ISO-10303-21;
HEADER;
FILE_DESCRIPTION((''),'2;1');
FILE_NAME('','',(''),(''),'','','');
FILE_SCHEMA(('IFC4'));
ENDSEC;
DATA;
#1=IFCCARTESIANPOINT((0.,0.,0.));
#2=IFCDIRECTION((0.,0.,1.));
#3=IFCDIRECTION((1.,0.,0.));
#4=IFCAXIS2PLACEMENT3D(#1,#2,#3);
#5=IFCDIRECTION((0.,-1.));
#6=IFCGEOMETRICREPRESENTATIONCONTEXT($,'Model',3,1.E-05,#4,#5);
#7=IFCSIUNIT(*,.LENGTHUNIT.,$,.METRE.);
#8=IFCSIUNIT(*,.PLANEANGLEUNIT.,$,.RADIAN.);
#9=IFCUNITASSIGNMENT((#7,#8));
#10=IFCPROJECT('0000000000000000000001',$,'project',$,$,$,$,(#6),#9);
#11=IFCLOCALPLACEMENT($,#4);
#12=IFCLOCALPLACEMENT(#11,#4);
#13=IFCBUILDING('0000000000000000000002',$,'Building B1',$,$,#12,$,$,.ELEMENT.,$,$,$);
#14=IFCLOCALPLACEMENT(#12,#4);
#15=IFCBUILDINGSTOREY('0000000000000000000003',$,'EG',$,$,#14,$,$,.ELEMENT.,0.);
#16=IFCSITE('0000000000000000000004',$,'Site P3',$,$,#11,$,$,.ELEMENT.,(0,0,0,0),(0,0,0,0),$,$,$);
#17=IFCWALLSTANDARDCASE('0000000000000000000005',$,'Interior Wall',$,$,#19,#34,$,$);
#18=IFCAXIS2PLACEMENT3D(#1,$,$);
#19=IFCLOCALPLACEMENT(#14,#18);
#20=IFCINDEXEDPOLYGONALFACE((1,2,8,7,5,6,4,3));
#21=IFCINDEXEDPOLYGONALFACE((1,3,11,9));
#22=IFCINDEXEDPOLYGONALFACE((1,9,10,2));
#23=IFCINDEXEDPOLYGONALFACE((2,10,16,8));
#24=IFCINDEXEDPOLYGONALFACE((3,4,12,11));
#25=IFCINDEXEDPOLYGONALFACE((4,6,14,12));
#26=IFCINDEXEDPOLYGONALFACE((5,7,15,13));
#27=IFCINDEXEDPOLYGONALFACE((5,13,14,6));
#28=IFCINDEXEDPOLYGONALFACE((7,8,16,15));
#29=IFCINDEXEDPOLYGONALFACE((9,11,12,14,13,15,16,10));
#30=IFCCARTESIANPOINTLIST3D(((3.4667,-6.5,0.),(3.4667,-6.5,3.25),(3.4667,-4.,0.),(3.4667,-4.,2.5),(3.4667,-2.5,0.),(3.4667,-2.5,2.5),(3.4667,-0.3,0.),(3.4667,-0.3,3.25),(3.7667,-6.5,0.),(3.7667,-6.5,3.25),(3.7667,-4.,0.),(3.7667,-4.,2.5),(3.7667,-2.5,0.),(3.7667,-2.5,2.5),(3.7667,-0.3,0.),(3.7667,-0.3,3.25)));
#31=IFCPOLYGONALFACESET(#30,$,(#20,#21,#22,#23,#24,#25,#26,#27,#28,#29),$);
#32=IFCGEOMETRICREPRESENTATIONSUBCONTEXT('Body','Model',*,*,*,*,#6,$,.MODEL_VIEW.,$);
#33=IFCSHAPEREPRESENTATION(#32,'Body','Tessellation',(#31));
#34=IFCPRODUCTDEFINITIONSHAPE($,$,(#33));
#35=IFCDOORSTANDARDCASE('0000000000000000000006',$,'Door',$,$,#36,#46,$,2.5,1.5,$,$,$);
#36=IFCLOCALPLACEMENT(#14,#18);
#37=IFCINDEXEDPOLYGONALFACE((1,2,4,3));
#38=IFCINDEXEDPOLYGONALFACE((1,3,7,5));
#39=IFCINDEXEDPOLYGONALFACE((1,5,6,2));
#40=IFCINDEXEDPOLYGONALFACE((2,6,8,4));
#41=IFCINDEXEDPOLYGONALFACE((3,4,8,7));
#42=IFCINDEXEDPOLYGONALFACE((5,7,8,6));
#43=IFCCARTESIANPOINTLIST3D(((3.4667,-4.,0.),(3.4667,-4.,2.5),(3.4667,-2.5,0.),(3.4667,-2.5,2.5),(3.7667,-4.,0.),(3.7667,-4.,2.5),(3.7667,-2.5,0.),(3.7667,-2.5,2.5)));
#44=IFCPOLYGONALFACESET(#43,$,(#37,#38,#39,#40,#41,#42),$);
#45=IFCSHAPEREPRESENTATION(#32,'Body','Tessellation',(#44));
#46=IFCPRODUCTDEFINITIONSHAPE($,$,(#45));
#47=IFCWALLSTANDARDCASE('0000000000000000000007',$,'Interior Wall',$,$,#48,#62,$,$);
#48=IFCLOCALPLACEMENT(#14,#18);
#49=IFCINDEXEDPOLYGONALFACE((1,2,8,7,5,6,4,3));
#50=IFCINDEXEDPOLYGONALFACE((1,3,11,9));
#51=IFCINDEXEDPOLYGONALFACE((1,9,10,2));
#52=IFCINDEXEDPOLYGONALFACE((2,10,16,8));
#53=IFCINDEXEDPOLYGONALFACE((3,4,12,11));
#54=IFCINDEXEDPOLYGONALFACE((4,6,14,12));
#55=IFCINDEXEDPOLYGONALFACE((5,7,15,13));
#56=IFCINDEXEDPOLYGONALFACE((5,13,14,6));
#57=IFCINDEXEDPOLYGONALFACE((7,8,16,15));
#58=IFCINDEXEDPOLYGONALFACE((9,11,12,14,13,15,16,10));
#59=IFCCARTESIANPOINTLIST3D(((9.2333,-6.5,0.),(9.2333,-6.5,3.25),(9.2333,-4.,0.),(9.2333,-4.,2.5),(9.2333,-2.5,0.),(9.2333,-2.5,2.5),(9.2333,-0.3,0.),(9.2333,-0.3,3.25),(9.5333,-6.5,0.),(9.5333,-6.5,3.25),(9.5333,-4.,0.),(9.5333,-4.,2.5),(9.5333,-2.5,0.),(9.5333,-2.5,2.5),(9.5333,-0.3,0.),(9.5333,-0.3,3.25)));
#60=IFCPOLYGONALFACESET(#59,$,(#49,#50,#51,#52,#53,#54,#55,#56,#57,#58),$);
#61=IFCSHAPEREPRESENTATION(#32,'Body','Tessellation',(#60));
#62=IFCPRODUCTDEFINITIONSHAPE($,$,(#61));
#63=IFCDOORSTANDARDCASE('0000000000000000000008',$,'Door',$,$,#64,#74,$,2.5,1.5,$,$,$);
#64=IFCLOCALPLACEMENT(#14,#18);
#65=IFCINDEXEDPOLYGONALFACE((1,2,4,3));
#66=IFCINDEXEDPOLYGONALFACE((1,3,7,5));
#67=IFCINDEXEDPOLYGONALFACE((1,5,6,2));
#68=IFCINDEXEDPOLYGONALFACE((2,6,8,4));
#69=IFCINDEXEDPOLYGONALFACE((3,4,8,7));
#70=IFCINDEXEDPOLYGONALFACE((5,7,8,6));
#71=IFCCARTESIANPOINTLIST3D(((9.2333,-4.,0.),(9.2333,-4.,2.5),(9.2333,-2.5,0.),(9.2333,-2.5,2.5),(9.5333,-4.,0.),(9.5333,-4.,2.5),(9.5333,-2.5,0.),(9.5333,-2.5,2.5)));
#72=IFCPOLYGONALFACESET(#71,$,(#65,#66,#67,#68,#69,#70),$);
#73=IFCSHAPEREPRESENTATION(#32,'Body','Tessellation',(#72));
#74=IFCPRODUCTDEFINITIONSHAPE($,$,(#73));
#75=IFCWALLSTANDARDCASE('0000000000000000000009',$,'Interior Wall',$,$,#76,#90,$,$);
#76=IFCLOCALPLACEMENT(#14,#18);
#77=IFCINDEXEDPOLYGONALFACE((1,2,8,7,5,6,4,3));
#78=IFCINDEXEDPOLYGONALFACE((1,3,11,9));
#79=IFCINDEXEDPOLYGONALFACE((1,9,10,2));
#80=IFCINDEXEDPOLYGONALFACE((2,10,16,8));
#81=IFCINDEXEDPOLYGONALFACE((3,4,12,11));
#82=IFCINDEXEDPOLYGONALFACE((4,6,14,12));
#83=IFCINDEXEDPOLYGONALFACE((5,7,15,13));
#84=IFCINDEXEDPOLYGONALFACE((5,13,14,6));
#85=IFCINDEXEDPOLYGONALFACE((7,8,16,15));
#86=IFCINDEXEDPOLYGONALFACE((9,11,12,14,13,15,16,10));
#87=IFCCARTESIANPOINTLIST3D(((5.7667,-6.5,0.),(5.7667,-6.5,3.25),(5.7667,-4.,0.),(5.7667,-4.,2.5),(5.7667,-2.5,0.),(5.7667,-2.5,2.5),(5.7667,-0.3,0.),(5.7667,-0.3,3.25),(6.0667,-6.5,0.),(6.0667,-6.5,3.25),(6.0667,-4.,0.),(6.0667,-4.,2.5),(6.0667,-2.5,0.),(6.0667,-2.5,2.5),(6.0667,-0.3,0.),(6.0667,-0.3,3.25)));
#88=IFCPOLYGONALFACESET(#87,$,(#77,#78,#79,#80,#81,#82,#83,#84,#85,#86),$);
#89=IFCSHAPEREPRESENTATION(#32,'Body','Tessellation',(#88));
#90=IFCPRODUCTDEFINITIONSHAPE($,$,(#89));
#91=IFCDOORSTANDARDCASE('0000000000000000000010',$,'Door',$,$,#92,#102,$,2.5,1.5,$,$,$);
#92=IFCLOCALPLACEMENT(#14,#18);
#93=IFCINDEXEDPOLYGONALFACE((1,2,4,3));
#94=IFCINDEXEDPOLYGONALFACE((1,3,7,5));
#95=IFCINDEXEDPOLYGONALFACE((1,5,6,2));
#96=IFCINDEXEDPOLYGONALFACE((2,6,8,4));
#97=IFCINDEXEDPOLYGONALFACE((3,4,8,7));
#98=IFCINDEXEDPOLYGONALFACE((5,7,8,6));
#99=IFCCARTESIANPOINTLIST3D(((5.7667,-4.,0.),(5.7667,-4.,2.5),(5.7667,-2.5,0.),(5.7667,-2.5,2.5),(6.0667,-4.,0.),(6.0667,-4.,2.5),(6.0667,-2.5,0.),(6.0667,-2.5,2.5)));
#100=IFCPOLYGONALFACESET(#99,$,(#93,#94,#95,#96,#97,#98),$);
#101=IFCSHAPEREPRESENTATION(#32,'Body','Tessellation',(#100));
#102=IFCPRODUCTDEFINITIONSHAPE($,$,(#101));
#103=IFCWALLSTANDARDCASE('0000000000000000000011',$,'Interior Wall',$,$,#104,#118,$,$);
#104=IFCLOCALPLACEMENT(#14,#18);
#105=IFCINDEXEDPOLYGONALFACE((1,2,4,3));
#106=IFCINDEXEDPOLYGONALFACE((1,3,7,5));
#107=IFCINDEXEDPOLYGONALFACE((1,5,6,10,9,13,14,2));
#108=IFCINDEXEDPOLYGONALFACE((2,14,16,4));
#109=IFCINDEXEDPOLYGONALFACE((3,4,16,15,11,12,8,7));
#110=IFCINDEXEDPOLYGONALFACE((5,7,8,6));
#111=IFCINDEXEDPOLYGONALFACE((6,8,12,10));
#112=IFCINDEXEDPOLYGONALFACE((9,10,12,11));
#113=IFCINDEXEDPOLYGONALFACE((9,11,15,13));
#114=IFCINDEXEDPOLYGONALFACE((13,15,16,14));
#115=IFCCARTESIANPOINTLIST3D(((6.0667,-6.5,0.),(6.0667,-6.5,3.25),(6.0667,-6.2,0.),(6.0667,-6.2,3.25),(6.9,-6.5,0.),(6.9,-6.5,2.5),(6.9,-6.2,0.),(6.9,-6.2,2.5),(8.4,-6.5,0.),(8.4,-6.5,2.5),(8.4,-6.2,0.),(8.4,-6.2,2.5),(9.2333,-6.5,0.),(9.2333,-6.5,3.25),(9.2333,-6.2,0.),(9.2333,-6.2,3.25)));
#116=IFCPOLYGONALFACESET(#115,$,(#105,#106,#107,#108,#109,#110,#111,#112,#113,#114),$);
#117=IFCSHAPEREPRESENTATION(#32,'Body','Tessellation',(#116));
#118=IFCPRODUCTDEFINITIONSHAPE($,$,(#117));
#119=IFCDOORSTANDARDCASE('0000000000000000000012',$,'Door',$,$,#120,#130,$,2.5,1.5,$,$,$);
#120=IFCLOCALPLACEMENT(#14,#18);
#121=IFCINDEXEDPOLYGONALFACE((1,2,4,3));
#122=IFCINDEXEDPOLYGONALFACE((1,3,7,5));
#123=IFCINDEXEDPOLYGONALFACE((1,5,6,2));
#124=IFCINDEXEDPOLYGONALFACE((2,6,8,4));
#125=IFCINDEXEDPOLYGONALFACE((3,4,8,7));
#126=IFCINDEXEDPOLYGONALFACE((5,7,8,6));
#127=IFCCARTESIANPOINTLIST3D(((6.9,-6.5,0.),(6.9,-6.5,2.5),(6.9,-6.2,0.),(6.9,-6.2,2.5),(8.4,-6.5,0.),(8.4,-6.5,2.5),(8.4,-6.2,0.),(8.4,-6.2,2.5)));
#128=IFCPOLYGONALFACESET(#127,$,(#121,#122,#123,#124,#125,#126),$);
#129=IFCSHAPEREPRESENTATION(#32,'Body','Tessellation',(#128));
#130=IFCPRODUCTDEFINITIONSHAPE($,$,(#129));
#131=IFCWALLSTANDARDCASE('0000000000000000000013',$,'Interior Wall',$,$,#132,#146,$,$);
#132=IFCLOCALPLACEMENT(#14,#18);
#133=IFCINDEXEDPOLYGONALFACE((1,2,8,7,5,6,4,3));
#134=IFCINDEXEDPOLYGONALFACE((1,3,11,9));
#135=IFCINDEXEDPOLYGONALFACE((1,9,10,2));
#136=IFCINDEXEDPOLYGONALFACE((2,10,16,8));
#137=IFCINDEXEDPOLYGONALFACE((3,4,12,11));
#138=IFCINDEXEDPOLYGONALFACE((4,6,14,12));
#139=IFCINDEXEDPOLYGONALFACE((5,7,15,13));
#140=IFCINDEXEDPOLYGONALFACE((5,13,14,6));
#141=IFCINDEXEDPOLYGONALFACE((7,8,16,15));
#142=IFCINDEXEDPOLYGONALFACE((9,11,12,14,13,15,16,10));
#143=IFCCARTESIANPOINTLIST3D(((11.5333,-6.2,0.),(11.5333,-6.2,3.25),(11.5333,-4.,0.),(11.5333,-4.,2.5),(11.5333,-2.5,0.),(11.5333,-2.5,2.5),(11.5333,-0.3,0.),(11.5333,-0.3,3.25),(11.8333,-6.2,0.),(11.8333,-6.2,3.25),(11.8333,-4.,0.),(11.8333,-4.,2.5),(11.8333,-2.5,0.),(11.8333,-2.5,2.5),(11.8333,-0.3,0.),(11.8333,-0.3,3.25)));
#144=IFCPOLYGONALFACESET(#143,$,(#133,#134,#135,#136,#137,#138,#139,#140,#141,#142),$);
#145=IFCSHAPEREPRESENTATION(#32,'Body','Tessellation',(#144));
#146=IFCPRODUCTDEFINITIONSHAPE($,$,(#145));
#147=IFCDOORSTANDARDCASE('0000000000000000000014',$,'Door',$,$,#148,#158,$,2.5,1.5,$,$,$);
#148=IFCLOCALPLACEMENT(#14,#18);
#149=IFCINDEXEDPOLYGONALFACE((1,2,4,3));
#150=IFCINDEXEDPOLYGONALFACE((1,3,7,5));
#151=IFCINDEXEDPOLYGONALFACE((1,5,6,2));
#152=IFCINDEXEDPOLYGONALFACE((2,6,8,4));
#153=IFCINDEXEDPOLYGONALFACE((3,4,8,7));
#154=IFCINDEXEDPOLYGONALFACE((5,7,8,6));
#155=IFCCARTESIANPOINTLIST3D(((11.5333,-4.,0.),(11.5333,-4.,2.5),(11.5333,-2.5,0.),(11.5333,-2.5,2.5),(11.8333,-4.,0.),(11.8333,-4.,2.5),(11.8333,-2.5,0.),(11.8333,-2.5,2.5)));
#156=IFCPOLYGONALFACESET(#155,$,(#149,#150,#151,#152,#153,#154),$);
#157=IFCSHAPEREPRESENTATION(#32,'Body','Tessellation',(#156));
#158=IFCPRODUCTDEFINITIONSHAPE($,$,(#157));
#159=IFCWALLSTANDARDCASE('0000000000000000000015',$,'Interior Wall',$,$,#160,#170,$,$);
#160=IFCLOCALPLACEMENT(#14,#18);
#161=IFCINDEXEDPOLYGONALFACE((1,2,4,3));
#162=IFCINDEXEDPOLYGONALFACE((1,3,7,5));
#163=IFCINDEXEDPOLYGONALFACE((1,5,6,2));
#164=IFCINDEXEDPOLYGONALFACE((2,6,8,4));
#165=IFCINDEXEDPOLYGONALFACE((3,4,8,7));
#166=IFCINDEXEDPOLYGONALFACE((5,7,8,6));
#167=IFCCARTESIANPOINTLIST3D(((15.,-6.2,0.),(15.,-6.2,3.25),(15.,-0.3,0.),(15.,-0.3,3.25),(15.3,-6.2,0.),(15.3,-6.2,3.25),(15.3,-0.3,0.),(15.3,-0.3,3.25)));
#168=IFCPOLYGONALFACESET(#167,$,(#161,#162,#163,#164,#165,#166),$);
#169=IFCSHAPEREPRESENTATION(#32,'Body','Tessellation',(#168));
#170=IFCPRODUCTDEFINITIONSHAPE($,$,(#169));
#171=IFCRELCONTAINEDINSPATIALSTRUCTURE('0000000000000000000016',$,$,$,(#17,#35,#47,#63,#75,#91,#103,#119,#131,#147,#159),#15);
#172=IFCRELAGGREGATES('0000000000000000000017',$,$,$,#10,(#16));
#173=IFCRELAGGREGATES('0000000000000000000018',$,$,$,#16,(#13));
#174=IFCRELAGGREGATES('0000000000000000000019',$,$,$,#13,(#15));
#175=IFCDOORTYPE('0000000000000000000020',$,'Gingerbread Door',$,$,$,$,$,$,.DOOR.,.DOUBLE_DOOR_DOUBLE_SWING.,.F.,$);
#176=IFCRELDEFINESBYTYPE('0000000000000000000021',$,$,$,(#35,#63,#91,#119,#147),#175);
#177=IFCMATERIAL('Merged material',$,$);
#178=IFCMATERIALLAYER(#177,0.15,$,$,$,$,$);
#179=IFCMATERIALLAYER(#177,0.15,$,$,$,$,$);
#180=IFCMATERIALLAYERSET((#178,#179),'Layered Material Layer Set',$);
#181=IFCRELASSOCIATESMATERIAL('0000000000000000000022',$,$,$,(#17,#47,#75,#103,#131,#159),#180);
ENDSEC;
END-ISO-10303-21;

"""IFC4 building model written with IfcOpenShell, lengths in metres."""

from ifc_helpers import new_model, si_unit, direction, frame, origin_with_axes, place, context, subcontext, project, spatial, polyline, outline, extrude, source, transform, mapped, material, layer, layer_set, layer_usage, type_object, element, fill, save


model = new_model("IFC4")

# Units and contexts
model_context = context("Model", 3, precision=1e-05, world=origin_with_axes(), true_north=direction((0.0, -1.0)))
body_context = subcontext(model_context, "Body", "Model", "MODEL_VIEW")
ifc_project = project(units=[si_unit("LENGTHUNIT", "METRE"), si_unit("PLANEANGLEUNIT", "RADIAN")], contexts=[model_context])

# Site, building, storey
site_placement = place(None, origin_with_axes())
site = spatial("IfcSite", under=ifc_project, at=site_placement, Name="Site P3", CompositionType="ELEMENT", RefLatitude=(0, 0, 0, 0), RefLongitude=(0, 0, 0, 0))
building_placement = place(site_placement, origin_with_axes())
building = spatial("IfcBuilding", under=site, at=building_placement, Name="Building B1", CompositionType="ELEMENT")
storey_placement = place(building_placement, origin_with_axes())
storey = spatial("IfcBuildingStorey", under=building, at=storey_placement, Name="EG", CompositionType="ELEMENT", Elevation=0.0)

# Shared definitions
ifc_material = material(Name="Merged material")

# Shared definitions
ifc_layer_1 = layer(ifc_material, 0.15)
ifc_layer_2 = layer(ifc_material, 0.15)
ifc_layer_set_1 = layer_set([ifc_layer_1, ifc_layer_2], Name="Layered Material Layer Set")
ifc_layer_usage_1 = layer_usage(ifc_layer_set_1, "AXIS2", "POSITIVE", -0.15)
door_type = type_object("IfcDoorType", Name="Gingerbread Door", OperationType="DOUBLE_DOOR_DOUBLE_SWING", ParameterTakesPrecedence=False, PredefinedType="DOOR")
shared_shape_1 = source(origin_with_axes(), body_context, "Body", "SweptSolid", [
    extrude(outline(polyline([(0.0, 0.0), (0.0, 1.5), (2.5, 1.5), (2.5, 0.0), (0.0, 0.0)])), frame((0.0, -0.15, 0.0), z_axis=(0.0, 1.0, 0.0), x_axis=(0.0, 0.0, 1.0)), (0.0, 0.0, 1.0), 0.3),
])

# Walls, openings, doors
wall_1_placement = place(storey_placement, frame((3.6167, -0.3, 0.0), z_axis=(0.0, 0.0, 1.0), x_axis=(0.0, -1.0, 0.0)))
wall_1 = element("IfcWallStandardCase", 1, at=wall_1_placement, inside=storey, material=ifc_layer_usage_1, Name="Interior Wall", context=body_context, shape_type="SweptSolid", body=[
    extrude(outline(polyline([(0.0, 0.15), (6.2, 0.15), (6.2, -0.15), (0.0, -0.15), (0.0, 0.15)])), origin_with_axes(), (0.0, 0.0, 1.0), 3.25),
])
opening_1_placement = place(wall_1_placement, frame((2.2, 0.0, 0.0), z_axis=(0.0, 0.0, 1.0), x_axis=(1.0, 0.0, 0.0)))
opening_1 = element("IfcOpeningStandardCase", 2, at=opening_1_placement, cuts=wall_1, context=body_context, shape_type="SweptSolid", body=[
    extrude(outline(polyline([(0.0, 0.0), (0.0, 1.5), (2.5, 1.5), (2.5, 0.0), (0.0, 0.0)])), frame((0.0, -0.15, 0.0), z_axis=(0.0, 1.0, 0.0), x_axis=(0.0, 0.0, 1.0)), (0.0, 0.0, 1.0), 0.3),
])
door_1_placement = place(opening_1_placement, origin_with_axes())
door_1 = element("IfcDoorStandardCase", 3, at=door_1_placement, inside=storey, type_object=door_type, Name="Door", OverallHeight=2.5, OverallWidth=1.5, context=body_context, shape_type="MappedRepresentation", body=[
    mapped(shared_shape_1, transform((0.0, 0.0, 0.0))),
])
fill(opening_1, door_1)
wall_2_placement = place(storey_placement, frame((9.3833, -0.3, 0.0), z_axis=(0.0, 0.0, 1.0), x_axis=(0.0, -1.0, 0.0)))
wall_2 = element("IfcWallStandardCase", 4, at=wall_2_placement, inside=storey, material=ifc_layer_usage_1, Name="Interior Wall", context=body_context, shape_type="SweptSolid", body=[
    extrude(outline(polyline([(0.0, 0.15), (6.2, 0.15), (6.2, -0.15), (0.0, -0.15), (0.0, 0.15)])), origin_with_axes(), (0.0, 0.0, 1.0), 3.25),
])
opening_2_placement = place(wall_2_placement, frame((2.2, 0.0, 0.0), z_axis=(0.0, 0.0, 1.0), x_axis=(1.0, 0.0, 0.0)))
opening_2 = element("IfcOpeningStandardCase", 5, at=opening_2_placement, cuts=wall_2, context=body_context, shape_type="SweptSolid", body=[
    extrude(outline(polyline([(0.0, 0.0), (0.0, 1.5), (2.5, 1.5), (2.5, 0.0), (0.0, 0.0)])), frame((0.0, -0.15, 0.0), z_axis=(0.0, 1.0, 0.0), x_axis=(0.0, 0.0, 1.0)), (0.0, 0.0, 1.0), 0.3),
])
door_2_placement = place(opening_2_placement, origin_with_axes())
door_2 = element("IfcDoorStandardCase", 6, at=door_2_placement, inside=storey, type_object=door_type, Name="Door", OverallHeight=2.5, OverallWidth=1.5, context=body_context, shape_type="MappedRepresentation", body=[
    mapped(shared_shape_1, transform((0.0, 0.0, 0.0))),
])
fill(opening_2, door_2)
wall_3_placement = place(storey_placement, frame((5.9167, -0.3, 0.0), z_axis=(0.0, 0.0, 1.0), x_axis=(0.0, -1.0, 0.0)))
wall_3 = element("IfcWallStandardCase", 7, at=wall_3_placement, inside=storey, material=ifc_layer_usage_1, Name="Interior Wall", context=body_context, shape_type="SweptSolid", body=[
    extrude(outline(polyline([(0.0, 0.15), (6.2, 0.15), (6.2, -0.15), (0.0, -0.15), (0.0, 0.15)])), origin_with_axes(), (0.0, 0.0, 1.0), 3.25),
])
opening_3_placement = place(wall_3_placement, frame((2.2, 0.0, 0.0), z_axis=(0.0, 0.0, 1.0), x_axis=(1.0, 0.0, 0.0)))
opening_3 = element("IfcOpeningStandardCase", 8, at=opening_3_placement, cuts=wall_3, context=body_context, shape_type="SweptSolid", body=[
    extrude(outline(polyline([(0.0, 0.0), (0.0, 1.5), (2.5, 1.5), (2.5, 0.0), (0.0, 0.0)])), frame((0.0, -0.15, 0.0), z_axis=(0.0, 1.0, 0.0), x_axis=(0.0, 0.0, 1.0)), (0.0, 0.0, 1.0), 0.3),
])
door_3_placement = place(opening_3_placement, origin_with_axes())
door_3 = element("IfcDoorStandardCase", 9, at=door_3_placement, inside=storey, type_object=door_type, Name="Door", OverallHeight=2.5, OverallWidth=1.5, context=body_context, shape_type="MappedRepresentation", body=[
    mapped(shared_shape_1, transform((0.0, 0.0, 0.0))),
])
fill(opening_3, door_3)
wall_4_placement = place(storey_placement, frame((6.0667, -6.35, 0.0), z_axis=(0.0, 0.0, 1.0), x_axis=(1.0, 0.0, 0.0)))
wall_4 = element("IfcWallStandardCase", 10, at=wall_4_placement, inside=storey, material=ifc_layer_usage_1, Name="Interior Wall", context=body_context, shape_type="SweptSolid", body=[
    extrude(outline(polyline([(0.0, 0.15), (3.1667, 0.15), (3.1667, -0.15), (0.0, -0.15), (0.0, 0.15)])), origin_with_axes(), (0.0, 0.0, 1.0), 3.25),
])
opening_4_placement = place(wall_4_placement, frame((0.8333, 0.0, 0.0), z_axis=(0.0, 0.0, 1.0), x_axis=(1.0, 0.0, 0.0)))
opening_4 = element("IfcOpeningStandardCase", 11, at=opening_4_placement, cuts=wall_4, context=body_context, shape_type="SweptSolid", body=[
    extrude(outline(polyline([(0.0, 0.0), (0.0, 1.5), (2.5, 1.5), (2.5, 0.0), (0.0, 0.0)])), frame((0.0, -0.15, 0.0), z_axis=(0.0, 1.0, 0.0), x_axis=(0.0, 0.0, 1.0)), (0.0, 0.0, 1.0), 0.3),
])
door_4_placement = place(opening_4_placement, origin_with_axes())
door_4 = element("IfcDoorStandardCase", 12, at=door_4_placement, inside=storey, type_object=door_type, Name="Door", OverallHeight=2.5, OverallWidth=1.5, context=body_context, shape_type="MappedRepresentation", body=[
    mapped(shared_shape_1, transform((0.0, 0.0, 0.0))),
])
fill(opening_4, door_4)
wall_5_placement = place(storey_placement, frame((11.6833, -0.3, 0.0), z_axis=(0.0, 0.0, 1.0), x_axis=(0.0, -1.0, 0.0)))
wall_5 = element("IfcWallStandardCase", 13, at=wall_5_placement, inside=storey, material=ifc_layer_usage_1, Name="Interior Wall", context=body_context, shape_type="SweptSolid", body=[
    extrude(outline(polyline([(0.0, 0.15), (5.9, 0.15), (5.9, -0.15), (0.0, -0.15), (0.0, 0.15)])), origin_with_axes(), (0.0, 0.0, 1.0), 3.25),
])
opening_5_placement = place(wall_5_placement, frame((2.2, 0.0, 0.0), z_axis=(0.0, 0.0, 1.0), x_axis=(1.0, 0.0, 0.0)))
opening_5 = element("IfcOpeningStandardCase", 14, at=opening_5_placement, cuts=wall_5, context=body_context, shape_type="SweptSolid", body=[
    extrude(outline(polyline([(0.0, 0.0), (0.0, 1.5), (2.5, 1.5), (2.5, 0.0), (0.0, 0.0)])), frame((0.0, -0.15, 0.0), z_axis=(0.0, 1.0, 0.0), x_axis=(0.0, 0.0, 1.0)), (0.0, 0.0, 1.0), 0.3),
])
door_5_placement = place(opening_5_placement, origin_with_axes())
door_5 = element("IfcDoorStandardCase", 15, at=door_5_placement, inside=storey, type_object=door_type, Name="Door", OverallHeight=2.5, OverallWidth=1.5, context=body_context, shape_type="MappedRepresentation", body=[
    mapped(shared_shape_1, transform((0.0, 0.0, 0.0))),
])
fill(opening_5, door_5)

# Wall
wall_6_placement = place(storey_placement, frame((15.15, -0.3, 0.0), z_axis=(0.0, 0.0, 1.0), x_axis=(0.0, -1.0, 0.0)))
element("IfcWallStandardCase", 16, at=wall_6_placement, inside=storey, material=ifc_layer_usage_1, Name="Interior Wall", context=body_context, shape_type="SweptSolid", body=[
    extrude(outline(polyline([(0.0, 0.15), (5.9, 0.15), (5.9, -0.15), (0.0, -0.15), (0.0, 0.15)])), origin_with_axes(), (0.0, 0.0, 1.0), 3.25),
])

save(model, "model.ifc")
